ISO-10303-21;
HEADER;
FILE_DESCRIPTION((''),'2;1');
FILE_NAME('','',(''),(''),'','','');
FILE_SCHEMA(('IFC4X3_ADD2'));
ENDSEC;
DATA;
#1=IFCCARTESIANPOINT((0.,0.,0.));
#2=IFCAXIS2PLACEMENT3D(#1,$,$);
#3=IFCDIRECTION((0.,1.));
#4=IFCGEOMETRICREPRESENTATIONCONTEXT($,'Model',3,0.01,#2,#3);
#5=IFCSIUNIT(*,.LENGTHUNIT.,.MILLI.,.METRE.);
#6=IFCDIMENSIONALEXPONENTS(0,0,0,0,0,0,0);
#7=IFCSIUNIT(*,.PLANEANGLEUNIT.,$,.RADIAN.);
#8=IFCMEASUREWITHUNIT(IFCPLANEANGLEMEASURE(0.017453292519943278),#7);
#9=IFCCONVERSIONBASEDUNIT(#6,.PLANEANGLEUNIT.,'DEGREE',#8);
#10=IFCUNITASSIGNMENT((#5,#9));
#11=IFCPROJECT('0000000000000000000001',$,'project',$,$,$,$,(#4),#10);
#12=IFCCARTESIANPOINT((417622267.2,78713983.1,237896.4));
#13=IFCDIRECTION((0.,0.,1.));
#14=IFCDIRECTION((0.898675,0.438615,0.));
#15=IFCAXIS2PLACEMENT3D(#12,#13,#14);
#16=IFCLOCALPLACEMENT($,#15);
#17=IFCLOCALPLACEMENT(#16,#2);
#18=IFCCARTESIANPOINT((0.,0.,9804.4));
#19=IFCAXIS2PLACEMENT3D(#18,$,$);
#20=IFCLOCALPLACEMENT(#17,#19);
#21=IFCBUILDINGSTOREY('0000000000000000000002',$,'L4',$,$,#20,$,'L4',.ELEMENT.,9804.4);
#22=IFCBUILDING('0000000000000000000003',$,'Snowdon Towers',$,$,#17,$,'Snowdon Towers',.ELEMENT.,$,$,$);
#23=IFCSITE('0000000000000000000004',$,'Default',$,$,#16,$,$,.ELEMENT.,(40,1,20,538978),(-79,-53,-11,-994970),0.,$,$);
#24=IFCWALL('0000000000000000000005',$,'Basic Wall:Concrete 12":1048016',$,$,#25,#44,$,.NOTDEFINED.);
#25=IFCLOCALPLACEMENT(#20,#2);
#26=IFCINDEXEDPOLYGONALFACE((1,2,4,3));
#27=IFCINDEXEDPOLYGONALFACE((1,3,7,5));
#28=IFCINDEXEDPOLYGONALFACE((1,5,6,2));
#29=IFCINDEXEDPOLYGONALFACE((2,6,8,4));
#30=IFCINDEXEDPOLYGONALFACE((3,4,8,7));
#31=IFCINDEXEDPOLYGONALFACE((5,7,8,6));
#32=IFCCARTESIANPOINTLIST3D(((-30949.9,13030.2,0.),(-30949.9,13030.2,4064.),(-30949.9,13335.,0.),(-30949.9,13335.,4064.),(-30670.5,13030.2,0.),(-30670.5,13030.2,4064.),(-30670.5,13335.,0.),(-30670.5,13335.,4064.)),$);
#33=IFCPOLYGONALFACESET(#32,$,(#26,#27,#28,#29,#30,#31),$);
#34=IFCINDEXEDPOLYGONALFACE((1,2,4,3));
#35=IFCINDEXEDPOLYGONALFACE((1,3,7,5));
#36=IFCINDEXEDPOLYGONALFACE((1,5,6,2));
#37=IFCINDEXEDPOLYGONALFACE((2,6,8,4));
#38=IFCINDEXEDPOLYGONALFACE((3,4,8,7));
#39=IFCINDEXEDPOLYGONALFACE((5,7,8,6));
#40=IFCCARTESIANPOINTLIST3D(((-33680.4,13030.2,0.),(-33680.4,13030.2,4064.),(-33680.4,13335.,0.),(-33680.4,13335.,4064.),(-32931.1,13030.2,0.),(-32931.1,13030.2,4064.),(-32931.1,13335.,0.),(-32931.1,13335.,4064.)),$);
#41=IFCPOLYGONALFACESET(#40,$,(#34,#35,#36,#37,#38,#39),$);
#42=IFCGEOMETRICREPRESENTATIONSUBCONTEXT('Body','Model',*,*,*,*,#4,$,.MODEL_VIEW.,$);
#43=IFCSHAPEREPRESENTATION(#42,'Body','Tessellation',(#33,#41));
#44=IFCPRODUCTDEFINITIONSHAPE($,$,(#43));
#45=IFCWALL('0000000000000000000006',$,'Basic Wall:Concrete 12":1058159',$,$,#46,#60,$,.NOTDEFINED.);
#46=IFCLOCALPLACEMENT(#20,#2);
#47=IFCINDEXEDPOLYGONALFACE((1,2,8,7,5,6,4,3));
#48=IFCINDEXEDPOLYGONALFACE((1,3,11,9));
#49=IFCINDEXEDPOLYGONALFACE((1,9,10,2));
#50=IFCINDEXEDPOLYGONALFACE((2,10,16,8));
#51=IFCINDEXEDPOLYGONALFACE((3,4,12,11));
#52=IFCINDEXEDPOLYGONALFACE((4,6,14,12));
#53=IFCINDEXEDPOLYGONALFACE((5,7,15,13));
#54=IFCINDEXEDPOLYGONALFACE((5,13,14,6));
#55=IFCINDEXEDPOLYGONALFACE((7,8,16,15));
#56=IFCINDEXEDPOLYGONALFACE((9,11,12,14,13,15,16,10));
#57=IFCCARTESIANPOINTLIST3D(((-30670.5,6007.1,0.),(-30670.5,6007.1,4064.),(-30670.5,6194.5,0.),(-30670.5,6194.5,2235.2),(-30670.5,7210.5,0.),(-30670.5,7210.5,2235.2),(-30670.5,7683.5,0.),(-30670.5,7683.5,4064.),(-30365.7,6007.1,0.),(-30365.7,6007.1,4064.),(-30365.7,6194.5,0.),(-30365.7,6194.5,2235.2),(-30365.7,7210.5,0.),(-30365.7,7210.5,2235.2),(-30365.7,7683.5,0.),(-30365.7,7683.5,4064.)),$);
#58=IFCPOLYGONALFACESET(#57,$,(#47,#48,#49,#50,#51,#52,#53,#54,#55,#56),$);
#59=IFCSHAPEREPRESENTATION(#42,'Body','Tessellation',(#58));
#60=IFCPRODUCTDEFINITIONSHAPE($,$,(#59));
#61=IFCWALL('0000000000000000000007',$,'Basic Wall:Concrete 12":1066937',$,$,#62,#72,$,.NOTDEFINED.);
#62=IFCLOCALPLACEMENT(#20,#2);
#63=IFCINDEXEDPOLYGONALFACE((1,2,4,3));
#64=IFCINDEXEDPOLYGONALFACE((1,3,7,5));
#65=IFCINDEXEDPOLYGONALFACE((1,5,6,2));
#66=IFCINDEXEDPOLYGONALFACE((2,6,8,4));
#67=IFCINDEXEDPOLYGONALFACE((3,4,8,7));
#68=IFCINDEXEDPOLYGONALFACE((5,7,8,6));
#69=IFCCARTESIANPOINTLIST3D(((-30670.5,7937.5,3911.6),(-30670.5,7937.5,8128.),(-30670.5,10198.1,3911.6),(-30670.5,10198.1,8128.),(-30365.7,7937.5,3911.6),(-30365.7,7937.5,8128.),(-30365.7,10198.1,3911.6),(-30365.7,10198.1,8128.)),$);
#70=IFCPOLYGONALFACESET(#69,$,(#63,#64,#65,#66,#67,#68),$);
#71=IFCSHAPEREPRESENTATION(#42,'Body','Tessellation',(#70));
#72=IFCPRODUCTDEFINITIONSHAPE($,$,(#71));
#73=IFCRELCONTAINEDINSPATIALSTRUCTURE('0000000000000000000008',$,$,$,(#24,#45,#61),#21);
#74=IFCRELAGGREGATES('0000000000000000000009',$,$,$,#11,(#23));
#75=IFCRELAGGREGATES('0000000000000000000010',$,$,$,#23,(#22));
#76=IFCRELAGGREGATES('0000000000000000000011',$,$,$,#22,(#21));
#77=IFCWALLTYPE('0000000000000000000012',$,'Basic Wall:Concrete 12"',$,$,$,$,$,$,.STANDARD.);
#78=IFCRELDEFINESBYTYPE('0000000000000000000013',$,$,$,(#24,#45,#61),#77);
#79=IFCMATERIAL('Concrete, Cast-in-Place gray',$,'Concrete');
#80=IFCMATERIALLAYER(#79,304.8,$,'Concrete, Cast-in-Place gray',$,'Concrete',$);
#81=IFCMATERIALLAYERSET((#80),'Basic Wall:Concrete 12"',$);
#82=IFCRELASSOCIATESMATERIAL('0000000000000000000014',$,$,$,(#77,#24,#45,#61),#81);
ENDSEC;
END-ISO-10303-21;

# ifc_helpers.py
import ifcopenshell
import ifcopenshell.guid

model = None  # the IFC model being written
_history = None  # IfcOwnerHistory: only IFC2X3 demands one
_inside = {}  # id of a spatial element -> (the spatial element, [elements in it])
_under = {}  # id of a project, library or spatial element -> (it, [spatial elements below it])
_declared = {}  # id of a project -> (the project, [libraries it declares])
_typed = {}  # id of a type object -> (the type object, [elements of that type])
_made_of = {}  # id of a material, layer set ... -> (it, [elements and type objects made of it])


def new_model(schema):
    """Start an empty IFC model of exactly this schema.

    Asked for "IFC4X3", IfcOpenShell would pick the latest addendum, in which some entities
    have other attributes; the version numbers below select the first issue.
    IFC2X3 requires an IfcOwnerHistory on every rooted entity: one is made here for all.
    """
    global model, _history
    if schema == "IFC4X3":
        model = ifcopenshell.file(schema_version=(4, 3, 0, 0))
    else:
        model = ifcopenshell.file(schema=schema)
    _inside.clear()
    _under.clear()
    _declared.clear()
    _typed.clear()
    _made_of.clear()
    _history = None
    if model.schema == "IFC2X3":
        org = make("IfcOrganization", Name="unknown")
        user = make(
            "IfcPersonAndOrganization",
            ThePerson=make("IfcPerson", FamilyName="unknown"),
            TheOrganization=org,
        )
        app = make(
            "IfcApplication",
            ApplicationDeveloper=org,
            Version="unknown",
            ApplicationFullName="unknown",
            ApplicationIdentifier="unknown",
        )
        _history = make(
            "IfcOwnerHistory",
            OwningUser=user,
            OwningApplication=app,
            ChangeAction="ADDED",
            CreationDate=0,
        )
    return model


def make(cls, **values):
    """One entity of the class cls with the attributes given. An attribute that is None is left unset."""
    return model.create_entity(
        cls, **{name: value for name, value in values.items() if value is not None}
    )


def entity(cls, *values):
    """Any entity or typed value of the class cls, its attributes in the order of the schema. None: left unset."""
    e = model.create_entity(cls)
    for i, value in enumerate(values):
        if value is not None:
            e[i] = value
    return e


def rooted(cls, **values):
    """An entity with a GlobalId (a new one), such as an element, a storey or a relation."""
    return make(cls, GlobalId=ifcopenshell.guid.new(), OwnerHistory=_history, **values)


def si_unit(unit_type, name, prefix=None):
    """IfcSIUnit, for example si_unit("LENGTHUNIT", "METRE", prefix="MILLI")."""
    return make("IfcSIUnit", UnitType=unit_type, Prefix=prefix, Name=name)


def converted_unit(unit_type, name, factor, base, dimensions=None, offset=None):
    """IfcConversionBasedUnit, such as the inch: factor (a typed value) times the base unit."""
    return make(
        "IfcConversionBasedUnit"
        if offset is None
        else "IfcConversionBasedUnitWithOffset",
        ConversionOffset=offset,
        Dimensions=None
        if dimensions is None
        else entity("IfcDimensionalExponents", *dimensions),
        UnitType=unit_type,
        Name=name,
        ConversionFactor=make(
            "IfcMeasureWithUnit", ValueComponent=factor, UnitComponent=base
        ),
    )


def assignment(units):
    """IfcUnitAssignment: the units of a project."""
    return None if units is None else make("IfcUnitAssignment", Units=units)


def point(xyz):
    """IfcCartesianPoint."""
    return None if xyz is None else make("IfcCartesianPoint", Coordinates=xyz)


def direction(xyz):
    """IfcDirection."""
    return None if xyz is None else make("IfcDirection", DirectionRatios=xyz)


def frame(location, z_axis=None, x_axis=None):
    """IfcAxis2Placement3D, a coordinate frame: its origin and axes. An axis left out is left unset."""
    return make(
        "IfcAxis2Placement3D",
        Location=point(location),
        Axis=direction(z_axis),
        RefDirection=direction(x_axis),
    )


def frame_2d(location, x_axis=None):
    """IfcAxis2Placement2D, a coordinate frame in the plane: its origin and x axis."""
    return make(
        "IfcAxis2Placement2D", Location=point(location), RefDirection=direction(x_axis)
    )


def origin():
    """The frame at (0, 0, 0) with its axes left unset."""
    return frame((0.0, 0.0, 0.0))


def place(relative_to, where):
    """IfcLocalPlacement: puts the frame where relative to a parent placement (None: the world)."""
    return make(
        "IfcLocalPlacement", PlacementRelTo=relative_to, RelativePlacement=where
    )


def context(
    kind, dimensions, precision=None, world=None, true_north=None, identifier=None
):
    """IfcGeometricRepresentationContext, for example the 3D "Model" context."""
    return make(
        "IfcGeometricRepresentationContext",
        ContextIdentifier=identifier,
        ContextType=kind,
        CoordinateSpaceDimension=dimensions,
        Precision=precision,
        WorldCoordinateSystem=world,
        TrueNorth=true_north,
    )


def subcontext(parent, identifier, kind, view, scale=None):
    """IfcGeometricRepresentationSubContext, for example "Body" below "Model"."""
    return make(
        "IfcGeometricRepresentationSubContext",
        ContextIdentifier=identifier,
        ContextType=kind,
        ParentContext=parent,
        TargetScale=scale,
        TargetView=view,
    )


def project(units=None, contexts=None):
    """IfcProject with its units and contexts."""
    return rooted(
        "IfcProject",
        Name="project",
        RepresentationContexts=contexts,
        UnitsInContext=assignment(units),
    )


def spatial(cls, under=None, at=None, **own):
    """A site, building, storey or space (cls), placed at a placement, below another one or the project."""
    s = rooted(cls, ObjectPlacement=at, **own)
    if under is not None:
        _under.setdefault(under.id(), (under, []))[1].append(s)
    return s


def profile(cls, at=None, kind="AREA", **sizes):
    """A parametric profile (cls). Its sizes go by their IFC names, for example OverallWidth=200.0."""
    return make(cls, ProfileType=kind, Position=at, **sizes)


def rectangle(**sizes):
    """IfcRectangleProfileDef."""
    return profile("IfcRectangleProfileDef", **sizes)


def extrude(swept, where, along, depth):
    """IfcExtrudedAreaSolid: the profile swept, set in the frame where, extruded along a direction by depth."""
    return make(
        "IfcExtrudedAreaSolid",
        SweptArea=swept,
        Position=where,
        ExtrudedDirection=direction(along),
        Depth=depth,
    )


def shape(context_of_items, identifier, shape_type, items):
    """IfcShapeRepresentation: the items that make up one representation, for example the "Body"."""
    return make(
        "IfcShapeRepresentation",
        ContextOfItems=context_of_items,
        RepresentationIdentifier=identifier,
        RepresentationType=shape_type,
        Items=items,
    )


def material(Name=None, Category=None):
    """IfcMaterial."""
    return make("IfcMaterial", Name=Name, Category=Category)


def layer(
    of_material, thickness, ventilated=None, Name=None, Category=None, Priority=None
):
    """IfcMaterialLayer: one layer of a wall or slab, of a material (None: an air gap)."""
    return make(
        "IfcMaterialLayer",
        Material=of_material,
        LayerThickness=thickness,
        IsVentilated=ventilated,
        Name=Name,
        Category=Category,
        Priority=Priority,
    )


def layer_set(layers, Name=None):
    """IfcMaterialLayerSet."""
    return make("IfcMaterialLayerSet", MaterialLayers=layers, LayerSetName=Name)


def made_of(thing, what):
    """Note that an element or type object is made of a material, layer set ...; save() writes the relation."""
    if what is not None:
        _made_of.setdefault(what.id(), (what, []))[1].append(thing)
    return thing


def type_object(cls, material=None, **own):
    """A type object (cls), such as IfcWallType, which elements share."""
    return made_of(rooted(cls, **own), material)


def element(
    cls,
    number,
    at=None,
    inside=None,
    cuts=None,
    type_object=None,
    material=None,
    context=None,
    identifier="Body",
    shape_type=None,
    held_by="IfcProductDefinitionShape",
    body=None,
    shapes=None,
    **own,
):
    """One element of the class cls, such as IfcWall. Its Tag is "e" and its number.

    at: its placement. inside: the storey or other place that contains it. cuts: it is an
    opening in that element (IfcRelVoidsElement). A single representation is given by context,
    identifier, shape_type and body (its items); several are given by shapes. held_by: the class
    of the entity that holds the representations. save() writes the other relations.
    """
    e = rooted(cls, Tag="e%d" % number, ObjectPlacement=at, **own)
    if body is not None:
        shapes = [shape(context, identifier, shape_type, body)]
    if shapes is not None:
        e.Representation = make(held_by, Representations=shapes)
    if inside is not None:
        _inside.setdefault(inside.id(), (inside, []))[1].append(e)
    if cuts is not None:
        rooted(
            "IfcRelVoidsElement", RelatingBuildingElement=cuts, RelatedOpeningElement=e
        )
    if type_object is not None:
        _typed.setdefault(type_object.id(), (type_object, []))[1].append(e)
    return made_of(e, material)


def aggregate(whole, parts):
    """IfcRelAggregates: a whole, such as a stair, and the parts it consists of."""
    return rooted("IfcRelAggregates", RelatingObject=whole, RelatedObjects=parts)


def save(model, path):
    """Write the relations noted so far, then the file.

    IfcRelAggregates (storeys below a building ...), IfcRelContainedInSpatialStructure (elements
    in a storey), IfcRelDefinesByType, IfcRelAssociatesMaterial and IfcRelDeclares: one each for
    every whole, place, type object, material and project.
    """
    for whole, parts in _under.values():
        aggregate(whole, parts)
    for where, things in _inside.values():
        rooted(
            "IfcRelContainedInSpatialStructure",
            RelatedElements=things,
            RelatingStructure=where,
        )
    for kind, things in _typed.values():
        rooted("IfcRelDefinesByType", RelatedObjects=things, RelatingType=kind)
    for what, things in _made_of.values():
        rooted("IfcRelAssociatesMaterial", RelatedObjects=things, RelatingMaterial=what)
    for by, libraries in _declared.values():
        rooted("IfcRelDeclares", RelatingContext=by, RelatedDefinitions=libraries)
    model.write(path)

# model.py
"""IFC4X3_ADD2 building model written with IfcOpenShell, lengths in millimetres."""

from ifc_helpers import new_model, entity, si_unit, converted_unit, direction, frame, frame_2d, origin, place, context, subcontext, project, spatial, rectangle, extrude, material, layer, layer_set, type_object, element, save


model = new_model("IFC4X3_ADD2")

# Units and contexts
model_context = context("Model", 3, precision=0.01, world=origin(), true_north=direction((0.0, 1.0)))
body_context = subcontext(model_context, "Body", "Model", "MODEL_VIEW")
ifc_project = project(units=[si_unit("LENGTHUNIT", "METRE", prefix="MILLI"), converted_unit("PLANEANGLEUNIT", "DEGREE", entity("IfcPlaneAngleMeasure", 0.017453292519943278), si_unit("PLANEANGLEUNIT", "RADIAN"), dimensions=[0, 0, 0, 0, 0, 0, 0])], contexts=[model_context])

# Site, building, storey
site_placement = place(None, frame((417622267.2, 78713983.1, 237896.4), z_axis=(0.0, 0.0, 1.0), x_axis=(0.898675, 0.438615, 0.0)))
site = spatial("IfcSite", under=ifc_project, at=site_placement, Name="Default", CompositionType="ELEMENT", RefLatitude=(40, 1, 20, 538978), RefLongitude=(-79, -53, -11, -994970), RefElevation=0.0)
building_placement = place(site_placement, origin())
building = spatial("IfcBuilding", under=site, at=building_placement, Name="Snowdon Towers", LongName="Snowdon Towers", CompositionType="ELEMENT")
storey_placement = place(building_placement, frame((0.0, 0.0, 9804.4)))
storey = spatial("IfcBuildingStorey", under=building, at=storey_placement, Name="L4", LongName="L4", CompositionType="ELEMENT", Elevation=9804.4)

# Shared definitions
ifc_material_1 = material(Name="Concrete, Cast-in-Place gray", Category="Concrete")

# Wall
ifc_layer_1 = layer(ifc_material_1, 304.8, Name="Concrete, Cast-in-Place gray", Category="Concrete")
ifc_layer_set_1 = layer_set([ifc_layer_1], Name="Basic Wall:Concrete 12\"")
wall_type_1 = type_object("IfcWallType", Name="Basic Wall:Concrete 12\"", PredefinedType="STANDARD", material=ifc_layer_set_1)
wall_1_placement = place(storey_placement, frame((-30670.5, 13182.6, 0.0), z_axis=(0.0, 0.0, 1.0), x_axis=(-1.0, 0.0, 0.0)))
element("IfcWall", 1, at=wall_1_placement, inside=storey, type_object=wall_type_1, material=ifc_layer_set_1, Name="Basic Wall:Concrete 12\":1048016", PredefinedType="NOTDEFINED", context=body_context, shape_type="SweptSolid", body=[
    extrude(rectangle(XDim=304.8, YDim=279.4, at=frame_2d((0.0, 0.0), x_axis=(1.0, 0.0))), frame((139.7, 0.0, 0.0), z_axis=(0.0, 0.0, 1.0), x_axis=(0.0, 1.0, 0.0)), (0.0, 0.0, 1.0), 4064.0),
    extrude(rectangle(XDim=304.8, YDim=749.3, at=frame_2d((0.0, 0.0), x_axis=(1.0, 0.0))), frame((2635.3, 0.0, 0.0), z_axis=(0.0, 0.0, 1.0), x_axis=(0.0, 1.0, 0.0)), (0.0, 0.0, 1.0), 4064.0),
])

# Wall, opening
wall_2_placement = place(storey_placement, frame((-30518.1, 7683.5, 0.0), z_axis=(0.0, 0.0, 1.0), x_axis=(0.0, -1.0, 0.0)))
wall_2 = element("IfcWall", 2, at=wall_2_placement, inside=storey, type_object=wall_type_1, material=ifc_layer_set_1, Name="Basic Wall:Concrete 12\":1058159", PredefinedType="NOTDEFINED", context=body_context, shape_type="SweptSolid", body=[
    extrude(rectangle(XDim=1676.4, YDim=304.8, at=frame_2d((838.2, 0.0), x_axis=(-1.0, 0.0))), origin(), (0.0, 0.0, 1.0), 4064.0),
])
opening_1_placement = place(wall_2_placement, origin())
element("IfcOpeningElement", 3, at=opening_1_placement, cuts=wall_2, PredefinedType="OPENING", context=body_context, shape_type="SweptSolid", body=[
    extrude(rectangle(XDim=2235.2, YDim=1016.0, at=frame_2d((0.0, 0.0), x_axis=(0.0, 1.0))), frame((981.0, 152.4, 1117.6), z_axis=(0.0, -1.0, 0.0), x_axis=(1.0, 0.0, 0.0)), (0.0, 0.0, 1.0), 304.8),
])

# Wall
wall_3_placement = place(storey_placement, frame((-30518.1, 7937.5, 3911.6), z_axis=(0.0, 0.0, 1.0), x_axis=(0.0, 1.0, 0.0)))
element("IfcWall", 4, at=wall_3_placement, inside=storey, type_object=wall_type_1, material=ifc_layer_set_1, Name="Basic Wall:Concrete 12\":1066937", PredefinedType="NOTDEFINED", context=body_context, shape_type="SweptSolid", body=[
    extrude(rectangle(XDim=2260.6, YDim=304.8, at=frame_2d((1130.3, 0.0), x_axis=(-1.0, 0.0))), origin(), (0.0, 0.0, 1.0), 4216.4),
])

save(model, "model.ifc")
